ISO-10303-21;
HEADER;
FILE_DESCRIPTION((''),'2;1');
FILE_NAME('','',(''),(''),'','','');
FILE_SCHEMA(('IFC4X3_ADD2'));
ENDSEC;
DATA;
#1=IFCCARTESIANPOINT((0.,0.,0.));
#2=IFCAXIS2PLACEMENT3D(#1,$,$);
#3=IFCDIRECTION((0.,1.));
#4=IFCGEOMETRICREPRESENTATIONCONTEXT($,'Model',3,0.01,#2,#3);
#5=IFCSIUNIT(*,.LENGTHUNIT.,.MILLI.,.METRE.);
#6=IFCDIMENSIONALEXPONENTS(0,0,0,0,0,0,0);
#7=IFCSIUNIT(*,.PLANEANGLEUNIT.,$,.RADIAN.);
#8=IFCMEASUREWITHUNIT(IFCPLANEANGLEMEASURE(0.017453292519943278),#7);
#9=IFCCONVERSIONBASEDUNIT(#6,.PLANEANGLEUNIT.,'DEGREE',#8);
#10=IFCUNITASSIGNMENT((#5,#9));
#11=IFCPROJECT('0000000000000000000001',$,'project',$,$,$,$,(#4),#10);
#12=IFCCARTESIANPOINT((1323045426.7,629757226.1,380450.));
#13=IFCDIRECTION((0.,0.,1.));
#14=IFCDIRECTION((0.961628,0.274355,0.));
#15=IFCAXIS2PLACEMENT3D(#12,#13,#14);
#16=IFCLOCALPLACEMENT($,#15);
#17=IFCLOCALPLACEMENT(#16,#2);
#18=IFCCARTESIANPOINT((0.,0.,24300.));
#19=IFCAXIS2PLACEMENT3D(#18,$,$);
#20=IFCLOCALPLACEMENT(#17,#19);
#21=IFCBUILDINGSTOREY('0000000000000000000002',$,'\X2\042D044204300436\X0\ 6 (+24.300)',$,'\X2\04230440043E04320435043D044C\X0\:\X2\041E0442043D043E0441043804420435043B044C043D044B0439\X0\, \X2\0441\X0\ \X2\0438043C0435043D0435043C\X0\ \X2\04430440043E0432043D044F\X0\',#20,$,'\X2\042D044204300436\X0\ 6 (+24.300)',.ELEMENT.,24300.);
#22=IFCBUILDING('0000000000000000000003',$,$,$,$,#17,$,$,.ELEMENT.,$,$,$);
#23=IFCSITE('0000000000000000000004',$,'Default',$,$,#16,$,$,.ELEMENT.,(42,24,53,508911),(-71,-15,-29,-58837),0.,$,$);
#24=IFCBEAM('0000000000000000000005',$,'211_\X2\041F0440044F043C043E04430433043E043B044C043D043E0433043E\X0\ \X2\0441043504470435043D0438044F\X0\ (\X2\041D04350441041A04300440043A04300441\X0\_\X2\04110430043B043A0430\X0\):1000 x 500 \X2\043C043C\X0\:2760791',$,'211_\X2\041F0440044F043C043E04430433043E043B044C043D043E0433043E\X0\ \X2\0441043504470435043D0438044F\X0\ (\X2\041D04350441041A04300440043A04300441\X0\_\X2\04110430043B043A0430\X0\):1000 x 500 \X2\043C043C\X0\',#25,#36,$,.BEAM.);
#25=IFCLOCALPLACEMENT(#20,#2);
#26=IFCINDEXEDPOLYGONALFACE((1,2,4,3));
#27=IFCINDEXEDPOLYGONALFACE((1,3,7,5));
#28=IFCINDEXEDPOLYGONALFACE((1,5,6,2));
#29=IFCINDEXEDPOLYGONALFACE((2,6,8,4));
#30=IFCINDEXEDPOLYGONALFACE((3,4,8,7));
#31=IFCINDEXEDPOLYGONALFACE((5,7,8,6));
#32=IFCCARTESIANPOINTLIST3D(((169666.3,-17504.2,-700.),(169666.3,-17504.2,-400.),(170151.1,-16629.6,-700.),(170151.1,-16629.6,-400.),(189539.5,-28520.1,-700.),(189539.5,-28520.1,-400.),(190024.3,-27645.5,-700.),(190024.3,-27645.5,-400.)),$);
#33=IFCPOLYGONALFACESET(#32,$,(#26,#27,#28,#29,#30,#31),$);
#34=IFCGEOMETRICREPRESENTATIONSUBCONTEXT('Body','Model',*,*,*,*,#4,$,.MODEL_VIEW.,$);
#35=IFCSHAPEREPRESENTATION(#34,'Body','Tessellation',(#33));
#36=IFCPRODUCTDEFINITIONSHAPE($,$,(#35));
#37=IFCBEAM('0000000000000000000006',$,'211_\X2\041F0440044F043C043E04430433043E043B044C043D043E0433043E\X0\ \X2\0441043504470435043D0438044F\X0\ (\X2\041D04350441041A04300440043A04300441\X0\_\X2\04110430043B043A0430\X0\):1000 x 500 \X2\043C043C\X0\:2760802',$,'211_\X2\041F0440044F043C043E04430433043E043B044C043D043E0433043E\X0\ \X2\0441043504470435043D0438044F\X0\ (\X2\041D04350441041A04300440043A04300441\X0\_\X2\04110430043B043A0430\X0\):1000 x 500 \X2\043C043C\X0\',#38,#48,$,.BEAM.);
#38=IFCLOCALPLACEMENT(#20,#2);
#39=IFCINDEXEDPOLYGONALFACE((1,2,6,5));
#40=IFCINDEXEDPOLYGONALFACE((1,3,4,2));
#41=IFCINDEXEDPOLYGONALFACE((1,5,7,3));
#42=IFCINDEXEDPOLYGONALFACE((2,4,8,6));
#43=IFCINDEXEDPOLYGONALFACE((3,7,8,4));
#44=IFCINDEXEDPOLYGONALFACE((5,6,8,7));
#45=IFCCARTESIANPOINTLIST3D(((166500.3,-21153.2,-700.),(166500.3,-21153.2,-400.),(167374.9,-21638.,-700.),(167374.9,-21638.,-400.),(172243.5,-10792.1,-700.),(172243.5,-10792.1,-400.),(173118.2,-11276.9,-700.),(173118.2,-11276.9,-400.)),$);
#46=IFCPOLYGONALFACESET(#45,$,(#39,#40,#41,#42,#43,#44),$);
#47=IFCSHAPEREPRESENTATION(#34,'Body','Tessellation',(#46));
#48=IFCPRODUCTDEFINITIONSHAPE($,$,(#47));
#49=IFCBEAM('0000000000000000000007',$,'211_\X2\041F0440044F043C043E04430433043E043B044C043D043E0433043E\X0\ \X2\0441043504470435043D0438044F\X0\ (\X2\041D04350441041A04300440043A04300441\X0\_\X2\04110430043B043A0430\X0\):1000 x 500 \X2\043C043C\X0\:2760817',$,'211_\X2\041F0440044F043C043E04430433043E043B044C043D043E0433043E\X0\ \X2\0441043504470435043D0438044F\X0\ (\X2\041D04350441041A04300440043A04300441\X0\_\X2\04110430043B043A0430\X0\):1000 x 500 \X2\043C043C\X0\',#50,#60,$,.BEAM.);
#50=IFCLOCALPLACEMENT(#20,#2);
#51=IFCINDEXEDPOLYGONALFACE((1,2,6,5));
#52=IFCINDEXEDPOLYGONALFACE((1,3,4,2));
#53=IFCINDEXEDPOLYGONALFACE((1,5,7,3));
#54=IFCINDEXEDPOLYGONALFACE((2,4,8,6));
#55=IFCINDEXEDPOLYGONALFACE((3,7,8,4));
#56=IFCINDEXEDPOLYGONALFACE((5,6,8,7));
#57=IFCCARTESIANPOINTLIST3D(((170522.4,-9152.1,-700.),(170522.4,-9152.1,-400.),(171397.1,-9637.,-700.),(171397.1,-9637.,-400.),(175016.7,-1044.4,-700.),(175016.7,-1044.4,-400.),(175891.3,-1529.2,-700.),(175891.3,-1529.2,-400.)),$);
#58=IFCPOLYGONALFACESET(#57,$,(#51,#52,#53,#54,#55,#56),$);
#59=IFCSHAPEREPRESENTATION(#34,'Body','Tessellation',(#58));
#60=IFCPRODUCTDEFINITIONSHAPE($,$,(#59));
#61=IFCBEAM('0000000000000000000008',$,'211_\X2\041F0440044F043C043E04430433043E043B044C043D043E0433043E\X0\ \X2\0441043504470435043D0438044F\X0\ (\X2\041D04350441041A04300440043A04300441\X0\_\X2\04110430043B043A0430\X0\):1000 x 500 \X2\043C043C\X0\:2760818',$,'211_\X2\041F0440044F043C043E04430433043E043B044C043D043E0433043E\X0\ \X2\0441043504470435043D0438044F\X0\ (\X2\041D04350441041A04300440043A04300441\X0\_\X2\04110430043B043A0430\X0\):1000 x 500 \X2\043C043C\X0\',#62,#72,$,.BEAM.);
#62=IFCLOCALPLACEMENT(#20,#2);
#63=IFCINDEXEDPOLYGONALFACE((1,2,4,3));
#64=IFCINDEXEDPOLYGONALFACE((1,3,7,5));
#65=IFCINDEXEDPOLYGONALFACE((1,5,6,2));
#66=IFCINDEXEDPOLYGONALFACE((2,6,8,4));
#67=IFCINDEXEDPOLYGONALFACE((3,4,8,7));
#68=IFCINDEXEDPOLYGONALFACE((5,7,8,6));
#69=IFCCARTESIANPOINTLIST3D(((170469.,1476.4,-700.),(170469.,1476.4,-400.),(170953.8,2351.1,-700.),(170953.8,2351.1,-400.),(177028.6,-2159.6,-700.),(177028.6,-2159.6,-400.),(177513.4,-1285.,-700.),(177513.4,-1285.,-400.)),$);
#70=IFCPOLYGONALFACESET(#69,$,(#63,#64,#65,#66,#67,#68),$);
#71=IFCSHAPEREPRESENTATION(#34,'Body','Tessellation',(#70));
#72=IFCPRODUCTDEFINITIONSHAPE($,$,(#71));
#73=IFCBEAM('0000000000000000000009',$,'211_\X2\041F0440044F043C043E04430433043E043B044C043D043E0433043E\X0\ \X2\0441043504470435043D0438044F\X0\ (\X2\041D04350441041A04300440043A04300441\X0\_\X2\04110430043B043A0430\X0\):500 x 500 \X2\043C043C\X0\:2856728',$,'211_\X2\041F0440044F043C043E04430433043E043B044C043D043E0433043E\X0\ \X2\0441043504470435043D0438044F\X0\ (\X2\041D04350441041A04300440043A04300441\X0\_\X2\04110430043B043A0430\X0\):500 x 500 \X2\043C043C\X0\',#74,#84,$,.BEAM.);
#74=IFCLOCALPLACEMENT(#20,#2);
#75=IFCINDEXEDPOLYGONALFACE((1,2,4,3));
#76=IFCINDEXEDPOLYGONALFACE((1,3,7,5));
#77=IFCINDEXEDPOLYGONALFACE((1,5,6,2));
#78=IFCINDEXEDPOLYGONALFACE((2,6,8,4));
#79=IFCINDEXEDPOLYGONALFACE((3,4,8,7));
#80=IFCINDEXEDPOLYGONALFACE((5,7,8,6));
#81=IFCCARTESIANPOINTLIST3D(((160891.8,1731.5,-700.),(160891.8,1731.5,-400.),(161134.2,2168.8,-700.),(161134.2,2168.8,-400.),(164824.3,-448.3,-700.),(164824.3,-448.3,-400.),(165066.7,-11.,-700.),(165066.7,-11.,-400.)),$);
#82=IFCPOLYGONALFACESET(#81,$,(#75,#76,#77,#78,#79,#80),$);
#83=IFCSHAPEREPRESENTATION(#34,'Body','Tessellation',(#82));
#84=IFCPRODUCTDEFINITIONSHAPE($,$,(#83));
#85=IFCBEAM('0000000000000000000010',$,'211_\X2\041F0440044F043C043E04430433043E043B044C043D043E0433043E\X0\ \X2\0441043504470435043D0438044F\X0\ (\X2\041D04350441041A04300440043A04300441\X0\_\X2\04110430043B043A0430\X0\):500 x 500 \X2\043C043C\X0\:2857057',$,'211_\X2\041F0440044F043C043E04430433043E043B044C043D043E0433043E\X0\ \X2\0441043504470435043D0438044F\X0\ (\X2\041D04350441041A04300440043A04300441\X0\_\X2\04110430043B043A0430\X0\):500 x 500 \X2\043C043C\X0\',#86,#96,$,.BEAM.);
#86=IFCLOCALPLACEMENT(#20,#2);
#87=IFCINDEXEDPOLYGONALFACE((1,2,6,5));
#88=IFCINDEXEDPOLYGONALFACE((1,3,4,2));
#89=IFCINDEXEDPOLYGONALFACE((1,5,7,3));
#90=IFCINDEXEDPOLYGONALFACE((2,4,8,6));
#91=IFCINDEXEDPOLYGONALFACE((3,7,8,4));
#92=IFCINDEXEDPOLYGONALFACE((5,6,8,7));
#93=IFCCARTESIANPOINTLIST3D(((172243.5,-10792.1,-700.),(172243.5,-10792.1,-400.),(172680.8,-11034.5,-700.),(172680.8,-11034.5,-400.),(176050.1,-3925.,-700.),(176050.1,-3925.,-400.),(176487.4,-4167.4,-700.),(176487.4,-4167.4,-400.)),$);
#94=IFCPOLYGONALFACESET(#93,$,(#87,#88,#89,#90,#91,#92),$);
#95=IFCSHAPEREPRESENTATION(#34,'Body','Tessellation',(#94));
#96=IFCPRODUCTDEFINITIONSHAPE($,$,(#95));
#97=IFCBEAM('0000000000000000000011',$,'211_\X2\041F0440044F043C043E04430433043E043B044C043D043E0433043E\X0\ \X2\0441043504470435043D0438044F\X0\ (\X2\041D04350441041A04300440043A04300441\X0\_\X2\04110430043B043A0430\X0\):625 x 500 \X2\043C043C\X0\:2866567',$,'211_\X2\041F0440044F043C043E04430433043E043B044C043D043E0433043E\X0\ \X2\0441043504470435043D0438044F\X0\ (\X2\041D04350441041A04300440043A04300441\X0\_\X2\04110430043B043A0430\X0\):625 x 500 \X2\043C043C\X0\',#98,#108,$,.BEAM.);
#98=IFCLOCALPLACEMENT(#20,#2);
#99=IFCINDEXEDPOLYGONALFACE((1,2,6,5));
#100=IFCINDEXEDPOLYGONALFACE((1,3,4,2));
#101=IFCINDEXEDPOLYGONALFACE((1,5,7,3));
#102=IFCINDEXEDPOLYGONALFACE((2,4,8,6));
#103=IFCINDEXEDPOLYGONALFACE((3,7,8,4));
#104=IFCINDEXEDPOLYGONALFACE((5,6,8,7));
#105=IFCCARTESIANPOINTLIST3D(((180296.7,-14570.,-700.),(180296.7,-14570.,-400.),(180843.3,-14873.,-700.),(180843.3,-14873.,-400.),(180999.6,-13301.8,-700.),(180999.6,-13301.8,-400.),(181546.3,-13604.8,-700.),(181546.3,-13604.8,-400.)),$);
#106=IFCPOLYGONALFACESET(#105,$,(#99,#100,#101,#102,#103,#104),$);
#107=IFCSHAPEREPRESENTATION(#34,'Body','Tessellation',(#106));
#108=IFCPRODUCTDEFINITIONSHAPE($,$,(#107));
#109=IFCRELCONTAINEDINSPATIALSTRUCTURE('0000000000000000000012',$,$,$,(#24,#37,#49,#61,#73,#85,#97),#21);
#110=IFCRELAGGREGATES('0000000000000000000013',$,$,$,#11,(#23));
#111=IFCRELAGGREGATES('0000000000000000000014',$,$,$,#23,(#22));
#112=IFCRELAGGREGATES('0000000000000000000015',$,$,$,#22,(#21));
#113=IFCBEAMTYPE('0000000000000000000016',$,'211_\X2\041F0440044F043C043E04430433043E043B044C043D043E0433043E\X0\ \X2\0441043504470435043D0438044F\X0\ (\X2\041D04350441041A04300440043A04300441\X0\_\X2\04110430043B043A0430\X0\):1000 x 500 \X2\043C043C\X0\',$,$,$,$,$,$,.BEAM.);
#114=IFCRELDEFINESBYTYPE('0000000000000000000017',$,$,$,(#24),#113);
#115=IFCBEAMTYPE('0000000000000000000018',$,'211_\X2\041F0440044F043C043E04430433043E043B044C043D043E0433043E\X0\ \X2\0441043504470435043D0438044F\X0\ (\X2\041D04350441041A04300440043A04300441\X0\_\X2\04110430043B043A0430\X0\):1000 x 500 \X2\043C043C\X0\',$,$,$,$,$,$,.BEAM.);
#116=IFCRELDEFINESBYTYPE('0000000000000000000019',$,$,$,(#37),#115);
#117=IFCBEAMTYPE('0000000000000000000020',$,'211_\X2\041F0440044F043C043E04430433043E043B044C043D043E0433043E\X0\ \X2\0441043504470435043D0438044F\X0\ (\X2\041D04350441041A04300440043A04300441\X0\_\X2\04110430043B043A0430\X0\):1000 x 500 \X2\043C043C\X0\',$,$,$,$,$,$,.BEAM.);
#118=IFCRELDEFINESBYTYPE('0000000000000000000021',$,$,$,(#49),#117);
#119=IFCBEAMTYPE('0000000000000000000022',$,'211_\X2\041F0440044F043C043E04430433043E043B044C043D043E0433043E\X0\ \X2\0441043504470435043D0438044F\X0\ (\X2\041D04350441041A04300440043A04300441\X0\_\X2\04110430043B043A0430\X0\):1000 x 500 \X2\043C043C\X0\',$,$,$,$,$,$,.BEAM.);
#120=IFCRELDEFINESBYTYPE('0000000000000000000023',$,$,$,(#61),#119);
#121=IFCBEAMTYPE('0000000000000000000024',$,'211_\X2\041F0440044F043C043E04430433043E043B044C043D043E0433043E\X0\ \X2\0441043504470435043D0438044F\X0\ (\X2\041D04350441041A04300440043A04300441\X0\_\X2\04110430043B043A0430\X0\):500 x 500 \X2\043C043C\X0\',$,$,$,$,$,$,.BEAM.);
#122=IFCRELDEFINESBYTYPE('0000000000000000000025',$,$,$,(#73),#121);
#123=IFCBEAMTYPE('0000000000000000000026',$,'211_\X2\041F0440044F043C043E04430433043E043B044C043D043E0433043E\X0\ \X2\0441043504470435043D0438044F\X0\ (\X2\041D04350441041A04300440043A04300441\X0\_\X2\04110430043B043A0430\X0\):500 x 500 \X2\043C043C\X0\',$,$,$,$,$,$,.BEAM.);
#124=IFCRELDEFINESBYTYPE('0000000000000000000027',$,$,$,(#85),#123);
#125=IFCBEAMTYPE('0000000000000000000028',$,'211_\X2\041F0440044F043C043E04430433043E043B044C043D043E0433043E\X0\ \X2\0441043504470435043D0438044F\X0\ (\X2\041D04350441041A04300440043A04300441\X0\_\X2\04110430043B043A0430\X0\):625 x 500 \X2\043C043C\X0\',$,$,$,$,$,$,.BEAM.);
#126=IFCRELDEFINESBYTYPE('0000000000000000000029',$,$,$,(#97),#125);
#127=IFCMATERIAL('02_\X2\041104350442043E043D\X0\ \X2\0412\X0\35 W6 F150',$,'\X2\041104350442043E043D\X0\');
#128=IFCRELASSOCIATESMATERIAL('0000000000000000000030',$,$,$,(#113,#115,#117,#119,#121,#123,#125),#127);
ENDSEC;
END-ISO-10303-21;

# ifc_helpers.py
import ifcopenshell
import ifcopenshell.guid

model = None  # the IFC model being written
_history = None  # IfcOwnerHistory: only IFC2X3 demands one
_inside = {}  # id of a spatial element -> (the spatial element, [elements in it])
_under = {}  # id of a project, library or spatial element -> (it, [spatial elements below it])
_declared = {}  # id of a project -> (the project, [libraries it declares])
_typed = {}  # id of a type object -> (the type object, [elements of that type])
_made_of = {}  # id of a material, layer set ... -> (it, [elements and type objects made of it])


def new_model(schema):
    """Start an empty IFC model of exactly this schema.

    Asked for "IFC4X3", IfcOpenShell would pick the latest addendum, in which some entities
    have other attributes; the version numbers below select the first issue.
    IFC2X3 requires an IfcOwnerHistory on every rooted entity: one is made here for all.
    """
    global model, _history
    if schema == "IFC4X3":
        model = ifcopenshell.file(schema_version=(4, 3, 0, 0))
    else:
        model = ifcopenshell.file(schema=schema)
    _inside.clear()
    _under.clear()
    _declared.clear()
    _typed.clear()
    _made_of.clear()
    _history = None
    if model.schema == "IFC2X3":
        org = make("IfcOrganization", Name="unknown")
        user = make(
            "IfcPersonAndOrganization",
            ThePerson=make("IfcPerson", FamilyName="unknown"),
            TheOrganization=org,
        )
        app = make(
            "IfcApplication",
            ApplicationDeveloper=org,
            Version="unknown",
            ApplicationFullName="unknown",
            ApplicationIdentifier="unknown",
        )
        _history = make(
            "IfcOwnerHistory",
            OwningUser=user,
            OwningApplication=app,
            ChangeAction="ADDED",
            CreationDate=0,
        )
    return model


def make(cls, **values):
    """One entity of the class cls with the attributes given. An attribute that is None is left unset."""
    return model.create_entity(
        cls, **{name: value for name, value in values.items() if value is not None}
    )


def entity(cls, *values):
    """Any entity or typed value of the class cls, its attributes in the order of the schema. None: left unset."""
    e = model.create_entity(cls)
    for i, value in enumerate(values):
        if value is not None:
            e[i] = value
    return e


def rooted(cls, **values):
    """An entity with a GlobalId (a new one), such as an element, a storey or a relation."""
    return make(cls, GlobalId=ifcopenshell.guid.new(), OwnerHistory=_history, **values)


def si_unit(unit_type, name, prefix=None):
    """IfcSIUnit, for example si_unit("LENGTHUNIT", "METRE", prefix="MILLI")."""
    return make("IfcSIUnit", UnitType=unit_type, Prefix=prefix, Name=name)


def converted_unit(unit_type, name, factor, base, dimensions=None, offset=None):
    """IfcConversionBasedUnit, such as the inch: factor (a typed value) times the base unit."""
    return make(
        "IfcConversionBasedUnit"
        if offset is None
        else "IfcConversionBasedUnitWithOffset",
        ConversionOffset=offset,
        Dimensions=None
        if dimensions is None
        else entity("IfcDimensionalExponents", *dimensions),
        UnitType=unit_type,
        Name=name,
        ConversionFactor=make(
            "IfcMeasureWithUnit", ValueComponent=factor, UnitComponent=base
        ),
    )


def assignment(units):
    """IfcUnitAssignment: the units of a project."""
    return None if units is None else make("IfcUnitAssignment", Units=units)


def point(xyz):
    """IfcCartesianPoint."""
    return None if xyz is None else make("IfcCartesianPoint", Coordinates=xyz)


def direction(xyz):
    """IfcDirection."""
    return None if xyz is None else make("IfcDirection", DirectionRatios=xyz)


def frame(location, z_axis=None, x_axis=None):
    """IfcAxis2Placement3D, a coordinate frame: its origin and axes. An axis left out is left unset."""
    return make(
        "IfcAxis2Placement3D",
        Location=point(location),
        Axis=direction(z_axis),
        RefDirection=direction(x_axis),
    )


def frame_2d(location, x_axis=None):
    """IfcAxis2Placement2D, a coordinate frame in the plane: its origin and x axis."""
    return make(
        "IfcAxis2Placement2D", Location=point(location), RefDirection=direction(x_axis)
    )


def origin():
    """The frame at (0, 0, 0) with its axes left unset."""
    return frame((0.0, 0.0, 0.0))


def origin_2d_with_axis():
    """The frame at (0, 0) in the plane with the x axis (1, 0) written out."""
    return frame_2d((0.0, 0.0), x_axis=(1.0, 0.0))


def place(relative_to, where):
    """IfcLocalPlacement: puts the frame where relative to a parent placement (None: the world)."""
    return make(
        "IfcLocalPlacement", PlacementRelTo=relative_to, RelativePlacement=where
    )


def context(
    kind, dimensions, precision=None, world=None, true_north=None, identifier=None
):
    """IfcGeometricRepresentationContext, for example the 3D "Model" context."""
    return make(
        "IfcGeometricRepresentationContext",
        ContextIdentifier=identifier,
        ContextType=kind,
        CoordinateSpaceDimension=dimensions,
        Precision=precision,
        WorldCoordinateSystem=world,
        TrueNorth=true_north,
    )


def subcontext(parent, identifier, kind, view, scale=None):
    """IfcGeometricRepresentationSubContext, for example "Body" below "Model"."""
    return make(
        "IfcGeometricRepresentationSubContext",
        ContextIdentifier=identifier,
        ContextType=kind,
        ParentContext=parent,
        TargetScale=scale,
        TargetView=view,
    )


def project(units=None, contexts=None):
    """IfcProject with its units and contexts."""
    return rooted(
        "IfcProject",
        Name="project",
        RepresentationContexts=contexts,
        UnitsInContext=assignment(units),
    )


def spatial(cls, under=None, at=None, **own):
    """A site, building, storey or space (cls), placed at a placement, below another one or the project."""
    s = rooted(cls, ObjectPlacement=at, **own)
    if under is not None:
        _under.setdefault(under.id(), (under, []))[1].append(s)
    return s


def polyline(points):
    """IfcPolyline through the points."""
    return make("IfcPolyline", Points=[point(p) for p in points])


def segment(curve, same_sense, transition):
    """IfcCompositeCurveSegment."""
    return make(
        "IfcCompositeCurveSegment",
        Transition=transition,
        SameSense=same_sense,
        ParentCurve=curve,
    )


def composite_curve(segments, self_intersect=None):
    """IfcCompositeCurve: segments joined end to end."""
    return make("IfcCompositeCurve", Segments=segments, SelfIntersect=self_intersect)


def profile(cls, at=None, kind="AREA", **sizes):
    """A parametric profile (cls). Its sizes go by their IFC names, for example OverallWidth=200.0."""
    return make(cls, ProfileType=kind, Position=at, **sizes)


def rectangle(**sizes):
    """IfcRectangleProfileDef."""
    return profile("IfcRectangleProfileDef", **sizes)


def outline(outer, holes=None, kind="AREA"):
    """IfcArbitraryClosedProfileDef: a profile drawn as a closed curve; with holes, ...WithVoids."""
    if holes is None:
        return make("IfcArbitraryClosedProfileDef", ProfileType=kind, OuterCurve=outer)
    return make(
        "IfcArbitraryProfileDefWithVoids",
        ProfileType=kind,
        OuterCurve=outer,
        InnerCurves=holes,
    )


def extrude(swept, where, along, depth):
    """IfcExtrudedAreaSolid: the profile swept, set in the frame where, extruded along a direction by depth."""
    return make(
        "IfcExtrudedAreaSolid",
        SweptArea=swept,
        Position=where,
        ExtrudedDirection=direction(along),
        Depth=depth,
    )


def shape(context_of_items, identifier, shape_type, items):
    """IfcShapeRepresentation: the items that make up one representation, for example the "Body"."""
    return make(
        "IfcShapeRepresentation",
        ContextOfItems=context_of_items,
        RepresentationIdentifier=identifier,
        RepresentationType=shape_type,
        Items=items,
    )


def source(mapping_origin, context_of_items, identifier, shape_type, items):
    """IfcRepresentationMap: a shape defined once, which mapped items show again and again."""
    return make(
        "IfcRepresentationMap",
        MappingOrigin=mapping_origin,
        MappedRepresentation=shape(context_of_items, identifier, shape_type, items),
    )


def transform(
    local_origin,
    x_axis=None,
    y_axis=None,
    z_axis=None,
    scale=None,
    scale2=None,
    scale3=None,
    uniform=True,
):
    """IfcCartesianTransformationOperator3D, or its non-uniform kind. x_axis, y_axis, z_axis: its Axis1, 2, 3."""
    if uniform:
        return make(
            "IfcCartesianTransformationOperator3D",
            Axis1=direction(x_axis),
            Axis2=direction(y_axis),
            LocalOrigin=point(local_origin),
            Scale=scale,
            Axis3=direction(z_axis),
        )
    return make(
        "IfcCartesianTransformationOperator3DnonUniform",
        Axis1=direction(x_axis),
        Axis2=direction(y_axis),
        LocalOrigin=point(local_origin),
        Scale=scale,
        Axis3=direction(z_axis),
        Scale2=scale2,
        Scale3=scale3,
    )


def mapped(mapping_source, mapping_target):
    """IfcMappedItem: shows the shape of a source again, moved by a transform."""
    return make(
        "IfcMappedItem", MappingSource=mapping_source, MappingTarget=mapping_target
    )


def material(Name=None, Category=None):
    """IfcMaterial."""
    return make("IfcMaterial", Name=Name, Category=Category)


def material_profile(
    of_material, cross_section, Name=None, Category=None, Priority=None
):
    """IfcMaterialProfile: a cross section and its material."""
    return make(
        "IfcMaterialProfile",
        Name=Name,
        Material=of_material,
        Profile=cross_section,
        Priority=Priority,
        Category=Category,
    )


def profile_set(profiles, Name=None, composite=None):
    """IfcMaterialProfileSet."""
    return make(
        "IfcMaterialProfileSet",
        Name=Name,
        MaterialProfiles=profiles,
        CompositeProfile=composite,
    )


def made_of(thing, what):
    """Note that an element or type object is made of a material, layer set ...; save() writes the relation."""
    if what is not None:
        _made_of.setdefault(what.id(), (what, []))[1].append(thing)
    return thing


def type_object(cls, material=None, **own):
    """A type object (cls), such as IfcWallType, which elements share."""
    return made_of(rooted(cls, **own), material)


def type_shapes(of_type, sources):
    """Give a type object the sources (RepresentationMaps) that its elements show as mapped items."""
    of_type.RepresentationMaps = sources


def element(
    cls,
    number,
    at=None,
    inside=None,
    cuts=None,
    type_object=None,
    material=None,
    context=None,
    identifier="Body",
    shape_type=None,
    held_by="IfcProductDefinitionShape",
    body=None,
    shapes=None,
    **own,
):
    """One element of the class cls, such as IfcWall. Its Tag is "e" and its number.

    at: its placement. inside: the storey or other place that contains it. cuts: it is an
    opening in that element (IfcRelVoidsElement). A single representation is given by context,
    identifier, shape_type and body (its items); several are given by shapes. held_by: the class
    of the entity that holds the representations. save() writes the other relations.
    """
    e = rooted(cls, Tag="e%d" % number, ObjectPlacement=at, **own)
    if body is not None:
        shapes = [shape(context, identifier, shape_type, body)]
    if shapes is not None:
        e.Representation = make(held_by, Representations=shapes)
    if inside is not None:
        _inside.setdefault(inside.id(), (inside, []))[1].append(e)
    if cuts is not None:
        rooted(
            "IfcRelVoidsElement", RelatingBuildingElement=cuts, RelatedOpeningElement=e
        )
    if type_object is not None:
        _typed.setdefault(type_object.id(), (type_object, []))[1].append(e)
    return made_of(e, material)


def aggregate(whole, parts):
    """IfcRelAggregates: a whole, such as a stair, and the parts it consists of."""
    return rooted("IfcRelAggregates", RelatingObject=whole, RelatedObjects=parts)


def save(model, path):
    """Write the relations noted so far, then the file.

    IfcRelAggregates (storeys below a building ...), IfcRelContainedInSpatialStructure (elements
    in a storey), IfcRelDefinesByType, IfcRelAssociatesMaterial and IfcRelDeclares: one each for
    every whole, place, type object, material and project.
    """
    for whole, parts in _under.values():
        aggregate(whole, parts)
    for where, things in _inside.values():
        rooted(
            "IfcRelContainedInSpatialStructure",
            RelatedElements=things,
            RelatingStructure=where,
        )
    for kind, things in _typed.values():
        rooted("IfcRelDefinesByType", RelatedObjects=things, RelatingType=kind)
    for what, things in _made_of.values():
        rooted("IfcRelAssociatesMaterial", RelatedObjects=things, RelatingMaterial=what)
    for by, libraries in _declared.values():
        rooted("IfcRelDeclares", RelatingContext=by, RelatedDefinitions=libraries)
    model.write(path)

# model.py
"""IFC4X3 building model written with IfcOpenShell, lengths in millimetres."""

from ifc_helpers import new_model, entity, si_unit, converted_unit, direction, frame, frame_2d, origin, origin_2d_with_axis, place, context, subcontext, project, spatial, polyline, segment, composite_curve, rectangle, outline, extrude, source, transform, mapped, material, material_profile, profile_set, type_object, type_shapes, element, save


model = new_model("IFC4X3")

# Units and contexts
model_context = context("Model", 3, precision=0.01, world=origin(), true_north=direction((0.0, 1.0)))
body_context = subcontext(model_context, "Body", "Model", "MODEL_VIEW")
ifc_project = project(units=[si_unit("LENGTHUNIT", "METRE", prefix="MILLI"), converted_unit("PLANEANGLEUNIT", "DEGREE", entity("IfcPlaneAngleMeasure", 0.017453292519943278), si_unit("PLANEANGLEUNIT", "RADIAN"), dimensions=[0, 0, 0, 0, 0, 0, 0])], contexts=[model_context])

# Site, building, storey
site_placement = place(None, frame((1323045426.7, 629757226.1, 380450.0), z_axis=(0.0, 0.0, 1.0), x_axis=(0.961628, 0.274355, 0.0)))
site = spatial("IfcSite", under=ifc_project, at=site_placement, Name="Default", CompositionType="ELEMENT", RefLatitude=(42, 24, 53, 508911), RefLongitude=(-71, -15, -29, -58837), RefElevation=0.0)
building_placement = place(site_placement, origin())
building = spatial("IfcBuilding", under=site, at=building_placement, CompositionType="ELEMENT")
storey_placement = place(building_placement, frame((0.0, 0.0, 24300.0)))
storey = spatial("IfcBuildingStorey", under=building, at=storey_placement, Name="Этаж 6 (+24.300)", ObjectType="Уровень:Относительный, с именем уровня", LongName="Этаж 6 (+24.300)", CompositionType="ELEMENT", Elevation=24300.0)

# Beams
ifc_material = material(Name="02_Бетон В35 W6 F150", Category="Бетон")
ifc_material_profile_1 = material_profile(ifc_material, outline(composite_curve([segment(polyline([(-500.0, 150.0, 0.0), (500.0, 150.0, 0.0)]), True, "CONTINUOUS"), segment(polyline([(500.0, 150.0, 0.0), (500.0, -150.0, 0.0)]), True, "CONTINUOUS"), segment(polyline([(500.0, -150.0, 0.0), (-500.0, -150.0, 0.0)]), True, "CONTINUOUS"), segment(polyline([(-500.0, -150.0, 0.0), (-500.0, 150.0, 0.0)]), True, "CONTINUOUS")], self_intersect=False), kind="CURVE"), Name="1000 x 500 мм")
ifc_profile_set_1 = profile_set([ifc_material_profile_1], Name="1000 x 500 мм")
beam_type_1 = type_object("IfcBeamType", Name="211_Прямоугольного сечения (НесКаркас_Балка):1000 x 500 мм", PredefinedType="BEAM", material=ifc_profile_set_1)
shared_shape_1 = source(origin(), body_context, "Body", "SweptSolid", [
    extrude(rectangle(XDim=300.0, YDim=1000.0, at=frame_2d((0.0, 0.0), x_axis=(1.0, 0.0))), frame((169908.7, -17066.9, 23750.0), z_axis=(0.87462, -0.48481, 0.0), x_axis=(0.0, 0.0, -1.0)), (0.0, 0.0, 1.0), 22722.1),
])
type_shapes(beam_type_1, [shared_shape_1])
beam_1_placement = place(storey_placement, frame((0.0, 0.0, -24300.0)))
element("IfcBeam", 1, at=beam_1_placement, inside=storey, type_object=beam_type_1, Name="211_Прямоугольного сечения (НесКаркас_Балка):1000 x 500 мм:2760791", ObjectType="211_Прямоугольного сечения (НесКаркас_Балка):1000 x 500 мм", PredefinedType="BEAM", context=body_context, shape_type="MappedRepresentation", body=[
    mapped(shared_shape_1, transform((0.0, 0.0, 0.0), scale=1.0)),
])
beam_type_2 = type_object("IfcBeamType", Name="211_Прямоугольного сечения (НесКаркас_Балка):1000 x 500 мм", PredefinedType="BEAM", material=ifc_profile_set_1)
shared_shape_2 = source(origin(), body_context, "Body", "SweptSolid", [
    extrude(rectangle(XDim=300.0, YDim=1000.0, at=frame_2d((0.0, 0.0), x_axis=(1.0, 0.0))), frame((172680.8, -11034.5, 23750.0), z_axis=(-0.48481, -0.87462, 0.0), x_axis=(0.0, 0.0, -1.0)), (0.0, 0.0, 1.0), 11846.4),
])
type_shapes(beam_type_2, [shared_shape_2])
beam_2_placement = place(storey_placement, frame((0.0, 0.0, -24300.0)))
element("IfcBeam", 2, at=beam_2_placement, inside=storey, type_object=beam_type_2, Name="211_Прямоугольного сечения (НесКаркас_Балка):1000 x 500 мм:2760802", ObjectType="211_Прямоугольного сечения (НесКаркас_Балка):1000 x 500 мм", PredefinedType="BEAM", context=body_context, shape_type="MappedRepresentation", body=[
    mapped(shared_shape_2, transform((0.0, 0.0, 0.0), scale=1.0)),
])
beam_type_3 = type_object("IfcBeamType", Name="211_Прямоугольного сечения (НесКаркас_Балка):1000 x 500 мм", PredefinedType="BEAM", material=ifc_profile_set_1)
shared_shape_3 = source(origin(), body_context, "Body", "SweptSolid", [
    extrude(rectangle(XDim=300.0, YDim=1000.0, at=frame_2d((0.0, 0.0), x_axis=(1.0, 0.0))), frame((175454.0, -1286.8, 23750.0), z_axis=(-0.484811, -0.874619, 0.0), x_axis=(0.0, 0.0, -1.0)), (0.0, 0.0, 1.0), 9270.0),
])
type_shapes(beam_type_3, [shared_shape_3])
beam_3_placement = place(storey_placement, frame((0.0, 0.0, -24300.0)))
element("IfcBeam", 3, at=beam_3_placement, inside=storey, type_object=beam_type_3, Name="211_Прямоугольного сечения (НесКаркас_Балка):1000 x 500 мм:2760817", ObjectType="211_Прямоугольного сечения (НесКаркас_Балка):1000 x 500 мм", PredefinedType="BEAM", context=body_context, shape_type="MappedRepresentation", body=[
    mapped(shared_shape_3, transform((0.0, 0.0, 0.0), scale=1.0)),
])
beam_type_4 = type_object("IfcBeamType", Name="211_Прямоугольного сечения (НесКаркас_Балка):1000 x 500 мм", PredefinedType="BEAM", material=ifc_profile_set_1)
shared_shape_4 = source(origin(), body_context, "Body", "SweptSolid", [
    extrude(rectangle(XDim=300.0, YDim=1000.0, at=frame_2d((0.0, 0.0), x_axis=(1.0, 0.0))), frame((170711.4, 1913.8, 23750.0), z_axis=(0.874619, -0.48481, 0.0), x_axis=(0.0, 0.0, -1.0)), (0.0, 0.0, 1.0), 7500.0),
])
type_shapes(beam_type_4, [shared_shape_4])
beam_4_placement = place(storey_placement, frame((0.0, 0.0, -24300.0)))
element("IfcBeam", 4, at=beam_4_placement, inside=storey, type_object=beam_type_4, Name="211_Прямоугольного сечения (НесКаркас_Балка):1000 x 500 мм:2760818", ObjectType="211_Прямоугольного сечения (НесКаркас_Балка):1000 x 500 мм", PredefinedType="BEAM", context=body_context, shape_type="MappedRepresentation", body=[
    mapped(shared_shape_4, transform((0.0, 0.0, 0.0), scale=1.0)),
])
ifc_material_profile_2 = material_profile(ifc_material, rectangle(XDim=300.0, YDim=500.0, at=frame_2d((0.0, 0.0), x_axis=(1.0, 0.0))), Name="500 x 500 мм")
ifc_profile_set_2 = profile_set([ifc_material_profile_2], Name="500 x 500 мм")
beam_type_5 = type_object("IfcBeamType", Name="211_Прямоугольного сечения (НесКаркас_Балка):500 x 500 мм", PredefinedType="BEAM", material=ifc_profile_set_2)
shared_shape_5 = source(origin(), body_context, "Body", "SweptSolid", [
    extrude(rectangle(XDim=300.0, YDim=500.0, at=frame_2d((0.0, 0.0), x_axis=(1.0, 0.0))), frame((161013.0, 1950.2, 23750.0), z_axis=(0.87462, -0.48481, 0.0), x_axis=(0.0, 0.0, -1.0)), (0.0, 0.0, 1.0), 4496.2),
])
type_shapes(beam_type_5, [shared_shape_5])
beam_5_placement = place(storey_placement, frame((0.0, 0.0, -24300.0)))
element("IfcBeam", 5, at=beam_5_placement, inside=storey, type_object=beam_type_5, Name="211_Прямоугольного сечения (НесКаркас_Балка):500 x 500 мм:2856728", ObjectType="211_Прямоугольного сечения (НесКаркас_Балка):500 x 500 мм", PredefinedType="BEAM", context=body_context, shape_type="MappedRepresentation", body=[
    mapped(shared_shape_5, transform((0.0, 0.0, 0.0), scale=1.0)),
])
beam_type_6 = type_object("IfcBeamType", Name="211_Прямоугольного сечения (НесКаркас_Балка):500 x 500 мм", PredefinedType="BEAM", material=ifc_profile_set_2)
shared_shape_6 = source(origin(), body_context, "Body", "SweptSolid", [
    extrude(rectangle(XDim=300.0, YDim=500.0, at=frame_2d((0.0, 0.0), x_axis=(1.0, 0.0))), frame((176268.7, -4046.2, 23750.0), z_axis=(-0.48481, -0.87462, 0.0), x_axis=(0.0, 0.0, -1.0)), (0.0, 0.0, 1.0), 7851.6),
])
type_shapes(beam_type_6, [shared_shape_6])
beam_6_placement = place(storey_placement, frame((0.0, 0.0, -24300.0)))
element("IfcBeam", 6, at=beam_6_placement, inside=storey, type_object=beam_type_6, Name="211_Прямоугольного сечения (НесКаркас_Балка):500 x 500 мм:2857057", ObjectType="211_Прямоугольного сечения (НесКаркас_Балка):500 x 500 мм", PredefinedType="BEAM", context=body_context, shape_type="MappedRepresentation", body=[
    mapped(shared_shape_6, transform((0.0, 0.0, 0.0), scale=1.0)),
])
ifc_material_profile_3 = material_profile(ifc_material, rectangle(XDim=300.0, YDim=625.0, at=origin_2d_with_axis()), Name="625 x 500 мм")
ifc_profile_set_3 = profile_set([ifc_material_profile_3], Name="625 x 500 мм")
beam_type_7 = type_object("IfcBeamType", Name="211_Прямоугольного сечения (НесКаркас_Балка):625 x 500 мм", PredefinedType="BEAM", material=ifc_profile_set_3)
shared_shape_7 = source(origin(), body_context, "Body", "SweptSolid", [
    extrude(rectangle(XDim=300.0, YDim=625.0, at=origin_2d_with_axis()), frame((181273.0, -13453.3, 23750.0), z_axis=(-0.48481, -0.87462, 0.0), x_axis=(0.0, 0.0, -1.0)), (0.0, 0.0, 1.0), 1450.0),
])
type_shapes(beam_type_7, [shared_shape_7])
beam_7_placement = place(storey_placement, frame((0.0, 0.0, -24300.0)))
element("IfcBeam", 7, at=beam_7_placement, inside=storey, type_object=beam_type_7, Name="211_Прямоугольного сечения (НесКаркас_Балка):625 x 500 мм:2866567", ObjectType="211_Прямоугольного сечения (НесКаркас_Балка):625 x 500 мм", PredefinedType="BEAM", context=body_context, shape_type="MappedRepresentation", body=[
    mapped(shared_shape_7, transform((0.0, 0.0, 0.0), scale=1.0)),
])

save(model, "model.ifc")
